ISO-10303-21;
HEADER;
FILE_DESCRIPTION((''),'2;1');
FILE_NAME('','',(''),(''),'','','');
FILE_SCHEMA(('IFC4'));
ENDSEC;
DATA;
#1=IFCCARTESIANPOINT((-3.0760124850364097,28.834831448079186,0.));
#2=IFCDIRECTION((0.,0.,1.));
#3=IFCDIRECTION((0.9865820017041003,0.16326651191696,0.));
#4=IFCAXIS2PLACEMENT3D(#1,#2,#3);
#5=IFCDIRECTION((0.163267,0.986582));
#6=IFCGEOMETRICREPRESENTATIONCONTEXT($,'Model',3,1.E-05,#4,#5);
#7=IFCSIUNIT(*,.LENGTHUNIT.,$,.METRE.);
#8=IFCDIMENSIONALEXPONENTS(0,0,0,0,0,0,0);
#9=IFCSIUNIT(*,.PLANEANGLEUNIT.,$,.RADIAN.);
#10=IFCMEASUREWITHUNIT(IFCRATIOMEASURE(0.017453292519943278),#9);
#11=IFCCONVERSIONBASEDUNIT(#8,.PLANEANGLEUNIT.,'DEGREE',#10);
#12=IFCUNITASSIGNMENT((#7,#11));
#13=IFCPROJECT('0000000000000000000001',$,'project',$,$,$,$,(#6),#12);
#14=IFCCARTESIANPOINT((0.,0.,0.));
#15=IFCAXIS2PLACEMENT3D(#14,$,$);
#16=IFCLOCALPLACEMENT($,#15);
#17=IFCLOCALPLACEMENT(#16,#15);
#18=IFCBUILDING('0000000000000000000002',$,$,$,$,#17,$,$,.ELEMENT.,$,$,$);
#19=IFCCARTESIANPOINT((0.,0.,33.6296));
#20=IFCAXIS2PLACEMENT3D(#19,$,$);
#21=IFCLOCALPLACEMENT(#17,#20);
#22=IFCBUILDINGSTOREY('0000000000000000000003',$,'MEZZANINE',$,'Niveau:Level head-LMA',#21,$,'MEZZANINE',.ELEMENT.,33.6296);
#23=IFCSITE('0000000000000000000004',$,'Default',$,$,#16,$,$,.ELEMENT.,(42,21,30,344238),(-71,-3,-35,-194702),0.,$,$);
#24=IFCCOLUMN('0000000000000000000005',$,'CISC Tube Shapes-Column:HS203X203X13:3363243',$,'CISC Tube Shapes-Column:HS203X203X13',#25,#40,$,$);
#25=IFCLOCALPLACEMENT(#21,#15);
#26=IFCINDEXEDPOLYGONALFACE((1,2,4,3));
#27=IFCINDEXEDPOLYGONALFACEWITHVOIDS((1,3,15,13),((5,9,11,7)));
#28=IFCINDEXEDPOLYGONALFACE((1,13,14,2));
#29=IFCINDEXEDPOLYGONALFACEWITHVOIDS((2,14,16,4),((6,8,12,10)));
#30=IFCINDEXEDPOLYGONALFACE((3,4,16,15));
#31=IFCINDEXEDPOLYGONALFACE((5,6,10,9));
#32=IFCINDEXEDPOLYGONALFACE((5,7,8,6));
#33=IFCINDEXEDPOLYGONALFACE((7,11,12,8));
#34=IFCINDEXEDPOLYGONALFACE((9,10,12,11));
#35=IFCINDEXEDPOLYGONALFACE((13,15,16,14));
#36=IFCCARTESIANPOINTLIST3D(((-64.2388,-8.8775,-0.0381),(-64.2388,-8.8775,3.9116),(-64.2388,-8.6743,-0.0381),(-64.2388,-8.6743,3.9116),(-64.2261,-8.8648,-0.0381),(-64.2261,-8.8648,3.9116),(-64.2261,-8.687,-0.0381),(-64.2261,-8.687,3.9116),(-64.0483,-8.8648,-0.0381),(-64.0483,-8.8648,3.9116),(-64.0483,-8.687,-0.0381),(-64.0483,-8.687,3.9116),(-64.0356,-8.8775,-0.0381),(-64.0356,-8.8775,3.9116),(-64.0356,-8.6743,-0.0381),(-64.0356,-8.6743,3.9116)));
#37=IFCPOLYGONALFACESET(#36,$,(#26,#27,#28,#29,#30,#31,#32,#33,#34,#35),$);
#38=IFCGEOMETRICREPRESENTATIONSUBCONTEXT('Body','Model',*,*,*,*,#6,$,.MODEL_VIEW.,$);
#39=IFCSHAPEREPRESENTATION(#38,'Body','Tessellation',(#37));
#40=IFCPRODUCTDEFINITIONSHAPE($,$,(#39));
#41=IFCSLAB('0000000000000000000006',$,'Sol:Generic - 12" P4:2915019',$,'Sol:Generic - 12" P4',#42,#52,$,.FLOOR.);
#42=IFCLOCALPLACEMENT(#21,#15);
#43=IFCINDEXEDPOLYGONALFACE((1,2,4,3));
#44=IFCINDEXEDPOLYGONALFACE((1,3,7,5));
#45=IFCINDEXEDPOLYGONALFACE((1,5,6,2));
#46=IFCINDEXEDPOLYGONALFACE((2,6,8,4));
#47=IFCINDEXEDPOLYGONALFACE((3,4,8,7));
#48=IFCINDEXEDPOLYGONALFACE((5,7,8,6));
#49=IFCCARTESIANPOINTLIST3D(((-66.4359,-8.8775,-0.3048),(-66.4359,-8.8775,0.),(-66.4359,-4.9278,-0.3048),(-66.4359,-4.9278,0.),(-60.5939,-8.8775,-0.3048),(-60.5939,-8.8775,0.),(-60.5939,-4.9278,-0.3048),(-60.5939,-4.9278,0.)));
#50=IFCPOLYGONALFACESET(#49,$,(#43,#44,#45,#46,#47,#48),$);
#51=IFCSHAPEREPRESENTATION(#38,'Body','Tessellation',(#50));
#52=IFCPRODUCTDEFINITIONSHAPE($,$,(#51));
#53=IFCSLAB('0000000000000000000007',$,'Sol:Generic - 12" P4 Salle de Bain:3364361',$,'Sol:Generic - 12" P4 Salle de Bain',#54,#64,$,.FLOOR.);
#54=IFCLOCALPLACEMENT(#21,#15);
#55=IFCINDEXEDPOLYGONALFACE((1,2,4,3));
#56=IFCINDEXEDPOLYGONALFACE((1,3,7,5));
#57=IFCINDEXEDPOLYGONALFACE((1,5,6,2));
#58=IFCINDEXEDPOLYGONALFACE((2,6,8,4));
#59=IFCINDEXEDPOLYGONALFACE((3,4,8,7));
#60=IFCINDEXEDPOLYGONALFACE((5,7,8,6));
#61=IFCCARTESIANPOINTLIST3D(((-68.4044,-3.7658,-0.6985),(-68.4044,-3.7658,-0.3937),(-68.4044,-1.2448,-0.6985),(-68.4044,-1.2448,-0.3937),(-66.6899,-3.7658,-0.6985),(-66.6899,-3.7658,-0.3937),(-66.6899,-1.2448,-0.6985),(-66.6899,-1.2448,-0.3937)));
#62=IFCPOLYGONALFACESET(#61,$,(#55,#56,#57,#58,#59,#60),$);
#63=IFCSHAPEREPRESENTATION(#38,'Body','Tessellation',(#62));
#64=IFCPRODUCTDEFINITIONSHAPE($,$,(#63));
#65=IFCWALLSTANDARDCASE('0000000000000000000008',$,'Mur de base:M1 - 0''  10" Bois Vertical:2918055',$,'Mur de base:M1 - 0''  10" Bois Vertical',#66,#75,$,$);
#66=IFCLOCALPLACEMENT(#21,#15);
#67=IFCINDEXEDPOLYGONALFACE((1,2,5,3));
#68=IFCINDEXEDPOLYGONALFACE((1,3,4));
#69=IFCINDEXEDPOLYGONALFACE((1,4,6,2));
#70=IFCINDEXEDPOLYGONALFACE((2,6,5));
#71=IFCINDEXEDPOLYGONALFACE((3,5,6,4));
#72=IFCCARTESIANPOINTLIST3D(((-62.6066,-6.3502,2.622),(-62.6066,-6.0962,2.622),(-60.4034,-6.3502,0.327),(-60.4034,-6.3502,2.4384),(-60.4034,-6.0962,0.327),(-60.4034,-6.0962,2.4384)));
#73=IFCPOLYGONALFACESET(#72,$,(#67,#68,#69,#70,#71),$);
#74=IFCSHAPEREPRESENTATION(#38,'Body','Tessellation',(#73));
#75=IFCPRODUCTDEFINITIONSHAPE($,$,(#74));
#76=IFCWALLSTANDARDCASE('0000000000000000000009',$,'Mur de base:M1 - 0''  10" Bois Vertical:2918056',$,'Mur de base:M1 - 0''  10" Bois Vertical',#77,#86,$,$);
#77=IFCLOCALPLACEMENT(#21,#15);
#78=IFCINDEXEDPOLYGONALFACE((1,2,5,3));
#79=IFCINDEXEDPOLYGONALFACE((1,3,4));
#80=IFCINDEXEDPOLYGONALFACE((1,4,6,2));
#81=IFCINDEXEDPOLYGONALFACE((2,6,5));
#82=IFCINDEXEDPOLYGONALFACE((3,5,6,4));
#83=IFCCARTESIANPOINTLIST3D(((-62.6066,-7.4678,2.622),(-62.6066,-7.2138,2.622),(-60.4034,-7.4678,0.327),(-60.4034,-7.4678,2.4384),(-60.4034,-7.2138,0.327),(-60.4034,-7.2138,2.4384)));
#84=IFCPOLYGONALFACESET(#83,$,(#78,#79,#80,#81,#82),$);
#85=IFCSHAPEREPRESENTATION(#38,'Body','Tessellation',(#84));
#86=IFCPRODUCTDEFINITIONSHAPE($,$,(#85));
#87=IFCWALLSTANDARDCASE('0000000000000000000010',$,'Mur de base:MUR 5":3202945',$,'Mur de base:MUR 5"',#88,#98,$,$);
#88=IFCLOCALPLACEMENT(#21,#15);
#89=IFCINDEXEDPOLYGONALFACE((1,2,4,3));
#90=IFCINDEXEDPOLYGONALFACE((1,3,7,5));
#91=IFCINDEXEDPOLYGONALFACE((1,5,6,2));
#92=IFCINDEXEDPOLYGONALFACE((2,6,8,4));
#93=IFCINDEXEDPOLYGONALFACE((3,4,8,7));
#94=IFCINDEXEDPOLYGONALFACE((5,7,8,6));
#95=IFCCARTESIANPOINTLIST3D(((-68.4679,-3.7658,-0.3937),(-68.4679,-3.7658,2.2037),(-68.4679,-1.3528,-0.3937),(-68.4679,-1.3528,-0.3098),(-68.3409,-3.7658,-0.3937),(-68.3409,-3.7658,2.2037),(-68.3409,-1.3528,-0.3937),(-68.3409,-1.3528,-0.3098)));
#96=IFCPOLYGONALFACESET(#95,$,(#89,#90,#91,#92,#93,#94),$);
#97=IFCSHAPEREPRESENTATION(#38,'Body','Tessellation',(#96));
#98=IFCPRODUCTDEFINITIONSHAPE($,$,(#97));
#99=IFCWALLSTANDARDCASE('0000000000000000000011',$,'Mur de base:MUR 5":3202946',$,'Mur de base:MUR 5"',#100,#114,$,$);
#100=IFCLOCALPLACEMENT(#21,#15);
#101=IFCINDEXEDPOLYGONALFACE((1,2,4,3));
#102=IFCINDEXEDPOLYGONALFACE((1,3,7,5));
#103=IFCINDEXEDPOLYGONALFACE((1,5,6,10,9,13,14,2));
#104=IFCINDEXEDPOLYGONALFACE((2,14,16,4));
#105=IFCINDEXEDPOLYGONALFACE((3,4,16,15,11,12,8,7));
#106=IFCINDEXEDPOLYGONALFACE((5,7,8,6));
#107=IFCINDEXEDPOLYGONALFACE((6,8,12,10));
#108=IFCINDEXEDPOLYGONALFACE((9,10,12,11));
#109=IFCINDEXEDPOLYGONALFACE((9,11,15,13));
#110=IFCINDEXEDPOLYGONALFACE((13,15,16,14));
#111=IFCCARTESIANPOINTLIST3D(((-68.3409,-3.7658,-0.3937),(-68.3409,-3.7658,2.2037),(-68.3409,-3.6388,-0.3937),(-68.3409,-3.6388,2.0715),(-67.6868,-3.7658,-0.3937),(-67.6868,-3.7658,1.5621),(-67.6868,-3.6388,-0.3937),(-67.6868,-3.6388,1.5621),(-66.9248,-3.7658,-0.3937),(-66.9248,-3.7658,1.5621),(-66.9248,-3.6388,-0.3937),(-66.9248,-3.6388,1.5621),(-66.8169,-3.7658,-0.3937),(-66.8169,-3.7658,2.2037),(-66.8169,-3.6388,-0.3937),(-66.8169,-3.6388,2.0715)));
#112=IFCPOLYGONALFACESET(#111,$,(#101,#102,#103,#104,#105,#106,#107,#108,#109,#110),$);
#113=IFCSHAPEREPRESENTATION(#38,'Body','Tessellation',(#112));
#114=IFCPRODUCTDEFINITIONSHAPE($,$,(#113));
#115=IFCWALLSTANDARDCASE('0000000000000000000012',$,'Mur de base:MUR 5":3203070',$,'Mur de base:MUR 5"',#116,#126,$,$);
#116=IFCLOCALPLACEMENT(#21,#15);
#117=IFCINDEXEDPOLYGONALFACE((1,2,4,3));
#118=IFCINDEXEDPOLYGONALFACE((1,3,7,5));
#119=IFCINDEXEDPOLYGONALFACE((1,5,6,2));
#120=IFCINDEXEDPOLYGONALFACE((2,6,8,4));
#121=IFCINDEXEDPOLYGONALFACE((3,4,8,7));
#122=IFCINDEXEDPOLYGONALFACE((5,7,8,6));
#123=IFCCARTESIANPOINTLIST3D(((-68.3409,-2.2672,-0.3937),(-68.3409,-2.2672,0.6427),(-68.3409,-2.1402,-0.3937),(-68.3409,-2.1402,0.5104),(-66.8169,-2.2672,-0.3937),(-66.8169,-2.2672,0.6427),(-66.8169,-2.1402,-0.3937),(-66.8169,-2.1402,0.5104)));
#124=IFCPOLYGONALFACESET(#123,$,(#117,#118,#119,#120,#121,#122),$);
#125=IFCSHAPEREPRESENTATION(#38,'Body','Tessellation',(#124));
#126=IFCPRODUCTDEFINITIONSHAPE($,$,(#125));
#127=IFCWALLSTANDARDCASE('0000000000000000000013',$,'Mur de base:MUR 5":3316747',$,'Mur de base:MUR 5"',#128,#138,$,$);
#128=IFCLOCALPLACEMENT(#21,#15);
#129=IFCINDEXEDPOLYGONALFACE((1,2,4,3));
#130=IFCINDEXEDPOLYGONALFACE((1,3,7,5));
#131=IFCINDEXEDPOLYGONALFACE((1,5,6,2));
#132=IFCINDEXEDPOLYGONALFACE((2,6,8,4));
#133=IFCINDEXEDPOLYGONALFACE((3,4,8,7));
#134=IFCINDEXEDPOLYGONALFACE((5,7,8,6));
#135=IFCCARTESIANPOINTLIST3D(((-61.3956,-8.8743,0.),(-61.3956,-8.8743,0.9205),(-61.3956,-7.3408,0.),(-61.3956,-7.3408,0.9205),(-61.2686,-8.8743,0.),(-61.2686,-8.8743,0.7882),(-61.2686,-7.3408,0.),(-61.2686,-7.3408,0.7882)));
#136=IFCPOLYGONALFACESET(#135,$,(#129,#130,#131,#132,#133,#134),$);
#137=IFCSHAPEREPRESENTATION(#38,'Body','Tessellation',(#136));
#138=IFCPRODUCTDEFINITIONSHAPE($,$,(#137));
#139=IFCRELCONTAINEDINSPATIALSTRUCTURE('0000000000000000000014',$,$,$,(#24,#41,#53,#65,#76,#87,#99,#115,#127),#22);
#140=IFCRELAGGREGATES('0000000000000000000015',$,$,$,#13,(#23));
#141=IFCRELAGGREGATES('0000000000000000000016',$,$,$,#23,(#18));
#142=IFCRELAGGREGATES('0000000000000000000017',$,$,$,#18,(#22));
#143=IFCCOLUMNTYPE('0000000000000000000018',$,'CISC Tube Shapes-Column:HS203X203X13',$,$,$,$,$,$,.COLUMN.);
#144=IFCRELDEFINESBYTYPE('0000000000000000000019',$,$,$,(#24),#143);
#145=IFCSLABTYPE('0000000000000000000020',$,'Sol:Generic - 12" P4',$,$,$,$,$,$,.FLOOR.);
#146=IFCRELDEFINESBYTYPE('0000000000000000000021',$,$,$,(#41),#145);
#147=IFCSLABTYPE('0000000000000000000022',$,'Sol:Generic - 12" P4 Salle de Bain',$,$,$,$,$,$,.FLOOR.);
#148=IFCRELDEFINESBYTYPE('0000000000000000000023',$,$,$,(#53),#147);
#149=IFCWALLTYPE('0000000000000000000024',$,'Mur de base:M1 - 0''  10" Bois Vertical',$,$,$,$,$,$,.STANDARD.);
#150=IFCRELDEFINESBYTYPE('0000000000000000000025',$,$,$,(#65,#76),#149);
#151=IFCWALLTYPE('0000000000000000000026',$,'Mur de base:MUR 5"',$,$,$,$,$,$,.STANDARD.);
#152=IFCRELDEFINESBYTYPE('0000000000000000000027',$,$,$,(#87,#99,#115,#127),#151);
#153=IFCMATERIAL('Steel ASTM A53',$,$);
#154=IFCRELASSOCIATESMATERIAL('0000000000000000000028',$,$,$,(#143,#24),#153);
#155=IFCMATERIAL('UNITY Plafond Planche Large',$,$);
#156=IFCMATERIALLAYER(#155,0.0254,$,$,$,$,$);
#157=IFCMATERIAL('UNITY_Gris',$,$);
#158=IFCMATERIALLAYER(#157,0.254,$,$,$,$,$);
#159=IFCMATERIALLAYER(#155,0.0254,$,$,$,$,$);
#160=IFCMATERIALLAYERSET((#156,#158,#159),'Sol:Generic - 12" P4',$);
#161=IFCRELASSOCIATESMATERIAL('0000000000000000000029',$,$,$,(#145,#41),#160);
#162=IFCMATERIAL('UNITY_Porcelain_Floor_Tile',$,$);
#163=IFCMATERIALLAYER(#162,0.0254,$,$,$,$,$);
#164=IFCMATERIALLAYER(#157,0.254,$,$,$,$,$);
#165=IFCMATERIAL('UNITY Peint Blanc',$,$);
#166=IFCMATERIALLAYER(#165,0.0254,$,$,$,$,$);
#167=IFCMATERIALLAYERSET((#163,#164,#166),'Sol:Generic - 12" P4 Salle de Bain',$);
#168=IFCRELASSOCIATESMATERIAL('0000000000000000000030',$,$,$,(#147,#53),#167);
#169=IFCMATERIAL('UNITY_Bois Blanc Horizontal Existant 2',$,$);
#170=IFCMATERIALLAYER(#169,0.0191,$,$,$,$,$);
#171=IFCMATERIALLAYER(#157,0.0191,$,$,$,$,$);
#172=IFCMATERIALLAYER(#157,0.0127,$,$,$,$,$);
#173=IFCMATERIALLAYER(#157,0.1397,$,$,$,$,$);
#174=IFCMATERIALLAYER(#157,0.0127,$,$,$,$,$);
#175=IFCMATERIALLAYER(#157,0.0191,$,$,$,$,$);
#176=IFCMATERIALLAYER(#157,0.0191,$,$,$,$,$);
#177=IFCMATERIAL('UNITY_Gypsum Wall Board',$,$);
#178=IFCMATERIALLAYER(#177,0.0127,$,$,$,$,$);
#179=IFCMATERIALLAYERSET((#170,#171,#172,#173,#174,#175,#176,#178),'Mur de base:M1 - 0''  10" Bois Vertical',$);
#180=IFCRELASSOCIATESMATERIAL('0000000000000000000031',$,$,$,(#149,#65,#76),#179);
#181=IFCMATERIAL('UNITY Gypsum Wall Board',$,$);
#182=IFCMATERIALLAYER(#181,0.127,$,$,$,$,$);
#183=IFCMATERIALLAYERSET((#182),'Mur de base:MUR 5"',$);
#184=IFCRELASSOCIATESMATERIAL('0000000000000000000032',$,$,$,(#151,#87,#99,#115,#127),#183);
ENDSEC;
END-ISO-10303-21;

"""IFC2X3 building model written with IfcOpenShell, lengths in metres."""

from ifc_helpers import new_model, entity, si_unit, converted_unit, direction, frame, frame_2d, origin, origin_2d_with_axis, place, context, subcontext, project, spatial, polyline, rectangle, outline, extrude, clip, bounded_halfspace, source, transform, mapped, material, layer, layer_set, layer_usage, type_object, type_shapes, element, save


model = new_model("IFC2X3")

# Units and contexts
model_context = context("Model", 3, precision=1e-05, world=frame((-3.0760124850364097, 28.834831448079186, 0.0), z_axis=(0.0, 0.0, 1.0), x_axis=(0.9865820017041003, 0.16326651191696, 0.0)), true_north=direction((0.163267, 0.986582)))
body_context = subcontext(model_context, "Body", "Model", "MODEL_VIEW")
ifc_project = project(units=[si_unit("LENGTHUNIT", "METRE"), converted_unit("PLANEANGLEUNIT", "DEGREE", entity("IfcRatioMeasure", 0.017453292519943278), si_unit("PLANEANGLEUNIT", "RADIAN"), dimensions=[0, 0, 0, 0, 0, 0, 0])], contexts=[model_context])

# Site, building, storey
site_placement = place(None, origin())
site = spatial("IfcSite", under=ifc_project, at=site_placement, Name="Default", CompositionType="ELEMENT", RefLatitude=(42, 21, 30, 344238), RefLongitude=(-71, -3, -35, -194702), RefElevation=0.0)
building_placement = place(site_placement, origin())
building = spatial("IfcBuilding", under=site, at=building_placement, CompositionType="ELEMENT")
storey_placement = place(building_placement, frame((0.0, 0.0, 33.6296)))
storey = spatial("IfcBuildingStorey", under=building, at=storey_placement, Name="MEZZANINE", ObjectType="Niveau:Level head-LMA", LongName="MEZZANINE", CompositionType="ELEMENT", Elevation=33.6296)

# Column
ifc_material_1 = material(Name="Steel ASTM A53")
column_type = type_object("IfcColumnType", Name="CISC Tube Shapes-Column:HS203X203X13", PredefinedType="COLUMN", material=ifc_material_1)
shared_shape_1 = source(origin(), body_context, "Body", "SweptSolid", [
    extrude(outline(polyline([(-0.1016, -0.1016), (0.1016, -0.1016), (0.1016, 0.1016), (-0.1016, 0.1016), (-0.1016, -0.1016)]), holes=[polyline([(-0.0889, -0.0889), (-0.0889, 0.0889), (0.0889, 0.0889), (0.0889, -0.0889), (-0.0889, -0.0889)])]), frame((0.0, 0.0, 33.5915), z_axis=(0.0, 0.0, 1.0), x_axis=(-1.0, 0.0, 0.0)), (0.0, 0.0, 1.0), 3.9497),
])
type_shapes(column_type, [shared_shape_1])
column_placement = place(storey_placement, frame((-64.1372, -8.7759, -33.6296)))
element("IfcColumn", 1, at=column_placement, inside=storey, type_object=column_type, material=ifc_material_1, Name="CISC Tube Shapes-Column:HS203X203X13:3363243", ObjectType="CISC Tube Shapes-Column:HS203X203X13", context=body_context, shape_type="MappedRepresentation", body=[
    mapped(shared_shape_1, transform((0.0, 0.0, 0.0), scale=1.0)),
])

# Slabs
ifc_material_2 = material(Name="UNITY Plafond Planche Large")
ifc_layer_1 = layer(ifc_material_2, 0.0254)
ifc_material_3 = material(Name="UNITY_Gris")
ifc_layer_2 = layer(ifc_material_3, 0.254)
ifc_layer_3 = layer(ifc_material_2, 0.0254)
ifc_layer_set_1 = layer_set([ifc_layer_1, ifc_layer_2, ifc_layer_3], Name="Sol:Generic - 12\" P4")
ifc_layer_usage_1 = layer_usage(ifc_layer_set_1, "AXIS3", "POSITIVE", 0.0)
slab_type_1 = type_object("IfcSlabType", Name="Sol:Generic - 12\" P4", PredefinedType="FLOOR", material=ifc_layer_set_1)
slab_1_placement = place(storey_placement, origin())
element("IfcSlab", 2, at=slab_1_placement, inside=storey, type_object=slab_type_1, material=ifc_layer_usage_1, Name="Sol:Generic - 12\" P4:2915019", ObjectType="Sol:Generic - 12\" P4", PredefinedType="FLOOR", context=body_context, shape_type="SweptSolid", body=[
    extrude(rectangle(XDim=3.9497, YDim=5.842, at=origin_2d_with_axis()), frame((-63.5149, -6.9027, 0.0), z_axis=(0.0, 0.0, -1.0), x_axis=(0.0, 1.0, 0.0)), (0.0, 0.0, 1.0), 0.3048),
])
ifc_material_4 = material(Name="UNITY Peint Blanc")
ifc_material_5 = material(Name="UNITY_Porcelain_Floor_Tile")
ifc_layer_4 = layer(ifc_material_5, 0.0254)
ifc_layer_5 = layer(ifc_material_3, 0.254)
ifc_layer_6 = layer(ifc_material_4, 0.0254)
ifc_layer_set_2 = layer_set([ifc_layer_4, ifc_layer_5, ifc_layer_6], Name="Sol:Generic - 12\" P4 Salle de Bain")
ifc_layer_usage_2 = layer_usage(ifc_layer_set_2, "AXIS3", "POSITIVE", 0.0)
slab_type_2 = type_object("IfcSlabType", Name="Sol:Generic - 12\" P4 Salle de Bain", PredefinedType="FLOOR", material=ifc_layer_set_2)
slab_2_placement = place(storey_placement, origin())
element("IfcSlab", 3, at=slab_2_placement, inside=storey, type_object=slab_type_2, material=ifc_layer_usage_2, Name="Sol:Generic - 12\" P4 Salle de Bain:3364361", ObjectType="Sol:Generic - 12\" P4 Salle de Bain", PredefinedType="FLOOR", context=body_context, shape_type="SweptSolid", body=[
    extrude(rectangle(XDim=2.521, YDim=1.7145, at=frame_2d((0.0, 0.0), x_axis=(1.0, 0.0))), frame((-67.5471, -2.5053, -0.3937), z_axis=(0.0, 0.0, -1.0), x_axis=(0.0, 1.0, 0.0)), (0.0, 0.0, 1.0), 0.3048),
])

# Shared definitions
ifc_material_6 = material(Name="UNITY_Bois Blanc Horizontal Existant 2")
ifc_material_7 = material(Name="UNITY_Gypsum Wall Board")

# Shared definitions
ifc_layer_7 = layer(ifc_material_6, 0.0191)
ifc_layer_8 = layer(ifc_material_3, 0.0191)
ifc_layer_9 = layer(ifc_material_3, 0.0127)
ifc_layer_10 = layer(ifc_material_3, 0.1397)
ifc_layer_11 = layer(ifc_material_3, 0.0127)
ifc_layer_12 = layer(ifc_material_3, 0.0191)
ifc_layer_13 = layer(ifc_material_3, 0.0191)
ifc_layer_14 = layer(ifc_material_7, 0.0127)
ifc_layer_set_3 = layer_set([ifc_layer_7, ifc_layer_8, ifc_layer_9, ifc_layer_10, ifc_layer_11, ifc_layer_12, ifc_layer_13, ifc_layer_14], Name="Mur de base:M1 - 0'  10\" Bois Vertical")
wall_type_1 = type_object("IfcWallType", Name="Mur de base:M1 - 0'  10\" Bois Vertical", PredefinedType="STANDARD", material=ifc_layer_set_3)

# Walls, openings
ifc_layer_usage_3 = layer_usage(ifc_layer_set_3, "AXIS2", "POSITIVE", -0.127)
wall_1_placement = place(storey_placement, frame((-60.4034, -6.2232, 0.327), z_axis=(0.0, 0.0, 1.0), x_axis=(-1.0, 0.0, 0.0)))
wall_1 = element("IfcWallStandardCase", 4, at=wall_1_placement, inside=storey, type_object=wall_type_1, material=ifc_layer_usage_3, Name="Mur de base:M1 - 0'  10\" Bois Vertical:2918055", ObjectType="Mur de base:M1 - 0'  10\" Bois Vertical", context=body_context, shape_type="Clipping", body=[
    clip(clip(extrude(rectangle(XDim=2.2032, YDim=0.254, at=frame_2d((1.1016, 0.0), x_axis=(-1.0, 0.0))), origin(), (0.0, 0.0, 1.0), 2.295), bounded_halfspace(frame((0.0, -0.127, 2.1114), z_axis=(-0.083045, 0.0, 0.996546), x_axis=(0.0, -1.0, 0.0)), False, frame((0.0, -0.127, 2.1114)), polyline([(0.0, 0.0), (2.2032, 0.0), (2.2032, 0.254), (0.254, 0.254), (0.0, 0.254), (0.0, 0.0)]))), bounded_halfspace(frame((2.2032, -0.127, 2.295), z_axis=(-0.721387, 0.0, 0.692532), x_axis=(0.0, -1.0, 0.0)), True, frame((2.2032, -0.127, 2.295)), polyline([(0.0, 0.0), (0.0, 0.254), (-2.2032, 0.254), (-2.2032, 0.0), (0.0, 0.0)]))),
])
opening_1_placement = place(wall_1_placement, origin())
element("IfcOpeningElement", 5, at=opening_1_placement, cuts=wall_1, ObjectType="Opening", context=body_context, shape_type="SweptSolid", body=[
    extrude(rectangle(XDim=2.0066, YDim=0.254, at=frame_2d((0.0, 0.0), x_axis=(0.0, 1.0))), frame((0.127, 0.127, 1.1081), z_axis=(0.0, 1.0, 0.0), x_axis=(1.0, 0.0, 0.0)), (0.0, 0.0, 1.0), 0.8636),
])
ifc_layer_usage_4 = layer_usage(ifc_layer_set_3, "AXIS2", "NEGATIVE", 0.127)
wall_2_placement = place(storey_placement, frame((-60.4034, -7.3408, 0.327), z_axis=(0.0, 0.0, 1.0), x_axis=(-1.0, 0.0, 0.0)))
wall_2 = element("IfcWallStandardCase", 6, at=wall_2_placement, inside=storey, type_object=wall_type_1, material=ifc_layer_usage_4, Name="Mur de base:M1 - 0'  10\" Bois Vertical:2918056", ObjectType="Mur de base:M1 - 0'  10\" Bois Vertical", context=body_context, shape_type="Clipping", body=[
    clip(clip(extrude(rectangle(XDim=2.2032, YDim=0.254, at=frame_2d((1.1016, 0.0), x_axis=(-1.0, 0.0))), origin(), (0.0, 0.0, 1.0), 2.295), bounded_halfspace(frame((0.0, 0.127, 2.1114), z_axis=(-0.083045, 0.0, 0.996546), x_axis=(0.0, -1.0, 0.0)), False, frame((0.0, 0.127, 2.1114)), polyline([(0.0, 0.0), (0.0, -0.254), (0.254, -0.254), (2.2032, -0.254), (2.2032, 0.0), (0.0, 0.0)]))), bounded_halfspace(frame((2.2032, -0.127, 2.295), z_axis=(-0.721387, 0.0, 0.692532), x_axis=(0.0, -1.0, 0.0)), True, frame((2.2032, -0.127, 2.295)), polyline([(0.0, 0.0), (0.0, 0.254), (-2.2032, 0.254), (-2.2032, 0.0), (0.0, 0.0)]))),
])
opening_2_placement = place(wall_2_placement, origin())
element("IfcOpeningElement", 7, at=opening_2_placement, cuts=wall_2, ObjectType="Opening", context=body_context, shape_type="SweptSolid", body=[
    extrude(rectangle(XDim=2.0066, YDim=0.254, at=frame_2d((0.0, 0.0), x_axis=(0.0, 1.0))), frame((0.127, -0.9906, 1.1081), z_axis=(0.0, 1.0, 0.0), x_axis=(1.0, 0.0, 0.0)), (0.0, 0.0, 1.0), 0.8636),
])

# Wall
ifc_material_8 = material(Name="UNITY Gypsum Wall Board")
ifc_layer_15 = layer(ifc_material_8, 0.127)
ifc_layer_set_4 = layer_set([ifc_layer_15], Name="Mur de base:MUR 5\"")
ifc_layer_usage_5 = layer_usage(ifc_layer_set_4, "AXIS2", "NEGATIVE", 0.0635)
wall_type_2 = type_object("IfcWallType", Name="Mur de base:MUR 5\"", PredefinedType="STANDARD", material=ifc_layer_set_4)
wall_3_placement = place(storey_placement, frame((-68.4044, -3.7658, -0.3937), z_axis=(0.0, 0.0, 1.0), x_axis=(0.0, 1.0, 0.0)))
element("IfcWallStandardCase", 8, at=wall_3_placement, inside=storey, type_object=wall_type_2, material=ifc_layer_usage_5, Name="Mur de base:MUR 5\":3202945", ObjectType="Mur de base:MUR 5\"", context=body_context, shape_type="Clipping", body=[
    clip(extrude(rectangle(XDim=2.413, YDim=0.127, at=frame_2d((1.2065, 0.0), x_axis=(-1.0, 0.0))), origin(), (0.0, 0.0, 1.0), 2.5974), bounded_halfspace(frame((0.0, -0.0635, 2.5974), z_axis=(0.721387, 0.0, 0.692532), x_axis=(0.0, 1.0, 0.0)), False, frame((0.0, -0.0635, 2.5974)), polyline([(0.0, 0.0), (0.127, 0.0), (1.4986, 0.0), (1.6256, 0.0), (2.413, 0.0), (2.413, 0.127), (0.0, 0.127), (0.0, 0.0)]))),
])

# Wall, opening
ifc_layer_usage_6 = layer_usage(ifc_layer_set_4, "AXIS2", "POSITIVE", -0.0635)
wall_4_placement = place(storey_placement, frame((-68.3409, -3.7023, -0.3937)))
wall_4 = element("IfcWallStandardCase", 9, at=wall_4_placement, inside=storey, type_object=wall_type_2, material=ifc_layer_usage_6, Name="Mur de base:MUR 5\":3202946", ObjectType="Mur de base:MUR 5\"", context=body_context, shape_type="Clipping", body=[
    clip(extrude(rectangle(XDim=1.524, YDim=0.127, at=frame_2d((0.762, 0.0), x_axis=(-1.0, 0.0))), origin(), (0.0, 0.0, 1.0), 2.5974), bounded_halfspace(frame((0.0, -0.0635, 2.5974), z_axis=(0.0, 0.721387, 0.692532), x_axis=(-1.0, 0.0, 0.0)), False, frame((0.0, -0.0635, 2.5974)), polyline([(0.0, 0.0), (1.524, 0.0), (1.524, 0.127), (0.0, 0.127), (0.0, 0.0)]))),
])
opening_3_placement = place(wall_4_placement, frame((68.3409, 3.7023, 0.3937)))
element("IfcOpeningElement", 10, at=opening_3_placement, cuts=wall_4, ObjectType="Opening", context=body_context, shape_type="SweptSolid", body=[
    extrude(rectangle(XDim=1.9558, YDim=0.762, at=frame_2d((0.0, 0.0), x_axis=(0.0, 1.0))), frame((-67.3058, -5.2898, 0.5842), z_axis=(0.0, 1.0, 0.0), x_axis=(-1.0, 0.0, 0.0)), (0.0, 0.0, 1.0), 3.048),
])

# Walls
ifc_layer_usage_7 = layer_usage(ifc_layer_set_4, "AXIS2", "POSITIVE", -0.0635)
wall_5_placement = place(storey_placement, frame((-68.3409, -2.2037, -0.3937)))
element("IfcWallStandardCase", 11, at=wall_5_placement, inside=storey, type_object=wall_type_2, material=ifc_layer_usage_7, Name="Mur de base:MUR 5\":3203070", ObjectType="Mur de base:MUR 5\"", context=body_context, shape_type="Clipping", body=[
    clip(extrude(rectangle(XDim=1.524, YDim=0.127, at=frame_2d((0.762, 0.0), x_axis=(-1.0, 0.0))), origin(), (0.0, 0.0, 1.0), 1.0364), bounded_halfspace(frame((0.0, -0.0635, 1.0364), z_axis=(0.0, 0.721387, 0.692532), x_axis=(-1.0, 0.0, 0.0)), False, frame((0.0, -0.0635, 1.0364)), polyline([(0.0, 0.0), (1.524, 0.0), (1.524, 0.127), (0.0, 0.127), (0.0, 0.0)]))),
])
ifc_layer_usage_8 = layer_usage(ifc_layer_set_4, "AXIS2", "NEGATIVE", 0.0635)
wall_6_placement = place(storey_placement, frame((-61.3321, -8.8743, 0.0), z_axis=(0.0, 0.0, 1.0), x_axis=(0.0, 1.0, 0.0)))
element("IfcWallStandardCase", 12, at=wall_6_placement, inside=storey, type_object=wall_type_2, material=ifc_layer_usage_8, Name="Mur de base:MUR 5\":3316747", ObjectType="Mur de base:MUR 5\"", context=body_context, shape_type="Clipping", body=[
    clip(extrude(rectangle(XDim=1.5335, YDim=0.127, at=frame_2d((0.7668, 0.0), x_axis=(-1.0, 0.0))), origin(), (0.0, 0.0, 1.0), 0.9205), bounded_halfspace(frame((0.0, -0.0635, 0.7882), z_axis=(0.0, -0.721387, 0.692532), x_axis=(1.0, 0.0, 0.0)), False, frame((0.0, -0.0635, 0.7882)), polyline([(0.0, 0.0), (0.127, 0.0), (1.5335, 0.0), (1.5335, 0.127), (0.0, 0.127), (0.0, 0.0)]))),
])

save(model, "model.ifc")
